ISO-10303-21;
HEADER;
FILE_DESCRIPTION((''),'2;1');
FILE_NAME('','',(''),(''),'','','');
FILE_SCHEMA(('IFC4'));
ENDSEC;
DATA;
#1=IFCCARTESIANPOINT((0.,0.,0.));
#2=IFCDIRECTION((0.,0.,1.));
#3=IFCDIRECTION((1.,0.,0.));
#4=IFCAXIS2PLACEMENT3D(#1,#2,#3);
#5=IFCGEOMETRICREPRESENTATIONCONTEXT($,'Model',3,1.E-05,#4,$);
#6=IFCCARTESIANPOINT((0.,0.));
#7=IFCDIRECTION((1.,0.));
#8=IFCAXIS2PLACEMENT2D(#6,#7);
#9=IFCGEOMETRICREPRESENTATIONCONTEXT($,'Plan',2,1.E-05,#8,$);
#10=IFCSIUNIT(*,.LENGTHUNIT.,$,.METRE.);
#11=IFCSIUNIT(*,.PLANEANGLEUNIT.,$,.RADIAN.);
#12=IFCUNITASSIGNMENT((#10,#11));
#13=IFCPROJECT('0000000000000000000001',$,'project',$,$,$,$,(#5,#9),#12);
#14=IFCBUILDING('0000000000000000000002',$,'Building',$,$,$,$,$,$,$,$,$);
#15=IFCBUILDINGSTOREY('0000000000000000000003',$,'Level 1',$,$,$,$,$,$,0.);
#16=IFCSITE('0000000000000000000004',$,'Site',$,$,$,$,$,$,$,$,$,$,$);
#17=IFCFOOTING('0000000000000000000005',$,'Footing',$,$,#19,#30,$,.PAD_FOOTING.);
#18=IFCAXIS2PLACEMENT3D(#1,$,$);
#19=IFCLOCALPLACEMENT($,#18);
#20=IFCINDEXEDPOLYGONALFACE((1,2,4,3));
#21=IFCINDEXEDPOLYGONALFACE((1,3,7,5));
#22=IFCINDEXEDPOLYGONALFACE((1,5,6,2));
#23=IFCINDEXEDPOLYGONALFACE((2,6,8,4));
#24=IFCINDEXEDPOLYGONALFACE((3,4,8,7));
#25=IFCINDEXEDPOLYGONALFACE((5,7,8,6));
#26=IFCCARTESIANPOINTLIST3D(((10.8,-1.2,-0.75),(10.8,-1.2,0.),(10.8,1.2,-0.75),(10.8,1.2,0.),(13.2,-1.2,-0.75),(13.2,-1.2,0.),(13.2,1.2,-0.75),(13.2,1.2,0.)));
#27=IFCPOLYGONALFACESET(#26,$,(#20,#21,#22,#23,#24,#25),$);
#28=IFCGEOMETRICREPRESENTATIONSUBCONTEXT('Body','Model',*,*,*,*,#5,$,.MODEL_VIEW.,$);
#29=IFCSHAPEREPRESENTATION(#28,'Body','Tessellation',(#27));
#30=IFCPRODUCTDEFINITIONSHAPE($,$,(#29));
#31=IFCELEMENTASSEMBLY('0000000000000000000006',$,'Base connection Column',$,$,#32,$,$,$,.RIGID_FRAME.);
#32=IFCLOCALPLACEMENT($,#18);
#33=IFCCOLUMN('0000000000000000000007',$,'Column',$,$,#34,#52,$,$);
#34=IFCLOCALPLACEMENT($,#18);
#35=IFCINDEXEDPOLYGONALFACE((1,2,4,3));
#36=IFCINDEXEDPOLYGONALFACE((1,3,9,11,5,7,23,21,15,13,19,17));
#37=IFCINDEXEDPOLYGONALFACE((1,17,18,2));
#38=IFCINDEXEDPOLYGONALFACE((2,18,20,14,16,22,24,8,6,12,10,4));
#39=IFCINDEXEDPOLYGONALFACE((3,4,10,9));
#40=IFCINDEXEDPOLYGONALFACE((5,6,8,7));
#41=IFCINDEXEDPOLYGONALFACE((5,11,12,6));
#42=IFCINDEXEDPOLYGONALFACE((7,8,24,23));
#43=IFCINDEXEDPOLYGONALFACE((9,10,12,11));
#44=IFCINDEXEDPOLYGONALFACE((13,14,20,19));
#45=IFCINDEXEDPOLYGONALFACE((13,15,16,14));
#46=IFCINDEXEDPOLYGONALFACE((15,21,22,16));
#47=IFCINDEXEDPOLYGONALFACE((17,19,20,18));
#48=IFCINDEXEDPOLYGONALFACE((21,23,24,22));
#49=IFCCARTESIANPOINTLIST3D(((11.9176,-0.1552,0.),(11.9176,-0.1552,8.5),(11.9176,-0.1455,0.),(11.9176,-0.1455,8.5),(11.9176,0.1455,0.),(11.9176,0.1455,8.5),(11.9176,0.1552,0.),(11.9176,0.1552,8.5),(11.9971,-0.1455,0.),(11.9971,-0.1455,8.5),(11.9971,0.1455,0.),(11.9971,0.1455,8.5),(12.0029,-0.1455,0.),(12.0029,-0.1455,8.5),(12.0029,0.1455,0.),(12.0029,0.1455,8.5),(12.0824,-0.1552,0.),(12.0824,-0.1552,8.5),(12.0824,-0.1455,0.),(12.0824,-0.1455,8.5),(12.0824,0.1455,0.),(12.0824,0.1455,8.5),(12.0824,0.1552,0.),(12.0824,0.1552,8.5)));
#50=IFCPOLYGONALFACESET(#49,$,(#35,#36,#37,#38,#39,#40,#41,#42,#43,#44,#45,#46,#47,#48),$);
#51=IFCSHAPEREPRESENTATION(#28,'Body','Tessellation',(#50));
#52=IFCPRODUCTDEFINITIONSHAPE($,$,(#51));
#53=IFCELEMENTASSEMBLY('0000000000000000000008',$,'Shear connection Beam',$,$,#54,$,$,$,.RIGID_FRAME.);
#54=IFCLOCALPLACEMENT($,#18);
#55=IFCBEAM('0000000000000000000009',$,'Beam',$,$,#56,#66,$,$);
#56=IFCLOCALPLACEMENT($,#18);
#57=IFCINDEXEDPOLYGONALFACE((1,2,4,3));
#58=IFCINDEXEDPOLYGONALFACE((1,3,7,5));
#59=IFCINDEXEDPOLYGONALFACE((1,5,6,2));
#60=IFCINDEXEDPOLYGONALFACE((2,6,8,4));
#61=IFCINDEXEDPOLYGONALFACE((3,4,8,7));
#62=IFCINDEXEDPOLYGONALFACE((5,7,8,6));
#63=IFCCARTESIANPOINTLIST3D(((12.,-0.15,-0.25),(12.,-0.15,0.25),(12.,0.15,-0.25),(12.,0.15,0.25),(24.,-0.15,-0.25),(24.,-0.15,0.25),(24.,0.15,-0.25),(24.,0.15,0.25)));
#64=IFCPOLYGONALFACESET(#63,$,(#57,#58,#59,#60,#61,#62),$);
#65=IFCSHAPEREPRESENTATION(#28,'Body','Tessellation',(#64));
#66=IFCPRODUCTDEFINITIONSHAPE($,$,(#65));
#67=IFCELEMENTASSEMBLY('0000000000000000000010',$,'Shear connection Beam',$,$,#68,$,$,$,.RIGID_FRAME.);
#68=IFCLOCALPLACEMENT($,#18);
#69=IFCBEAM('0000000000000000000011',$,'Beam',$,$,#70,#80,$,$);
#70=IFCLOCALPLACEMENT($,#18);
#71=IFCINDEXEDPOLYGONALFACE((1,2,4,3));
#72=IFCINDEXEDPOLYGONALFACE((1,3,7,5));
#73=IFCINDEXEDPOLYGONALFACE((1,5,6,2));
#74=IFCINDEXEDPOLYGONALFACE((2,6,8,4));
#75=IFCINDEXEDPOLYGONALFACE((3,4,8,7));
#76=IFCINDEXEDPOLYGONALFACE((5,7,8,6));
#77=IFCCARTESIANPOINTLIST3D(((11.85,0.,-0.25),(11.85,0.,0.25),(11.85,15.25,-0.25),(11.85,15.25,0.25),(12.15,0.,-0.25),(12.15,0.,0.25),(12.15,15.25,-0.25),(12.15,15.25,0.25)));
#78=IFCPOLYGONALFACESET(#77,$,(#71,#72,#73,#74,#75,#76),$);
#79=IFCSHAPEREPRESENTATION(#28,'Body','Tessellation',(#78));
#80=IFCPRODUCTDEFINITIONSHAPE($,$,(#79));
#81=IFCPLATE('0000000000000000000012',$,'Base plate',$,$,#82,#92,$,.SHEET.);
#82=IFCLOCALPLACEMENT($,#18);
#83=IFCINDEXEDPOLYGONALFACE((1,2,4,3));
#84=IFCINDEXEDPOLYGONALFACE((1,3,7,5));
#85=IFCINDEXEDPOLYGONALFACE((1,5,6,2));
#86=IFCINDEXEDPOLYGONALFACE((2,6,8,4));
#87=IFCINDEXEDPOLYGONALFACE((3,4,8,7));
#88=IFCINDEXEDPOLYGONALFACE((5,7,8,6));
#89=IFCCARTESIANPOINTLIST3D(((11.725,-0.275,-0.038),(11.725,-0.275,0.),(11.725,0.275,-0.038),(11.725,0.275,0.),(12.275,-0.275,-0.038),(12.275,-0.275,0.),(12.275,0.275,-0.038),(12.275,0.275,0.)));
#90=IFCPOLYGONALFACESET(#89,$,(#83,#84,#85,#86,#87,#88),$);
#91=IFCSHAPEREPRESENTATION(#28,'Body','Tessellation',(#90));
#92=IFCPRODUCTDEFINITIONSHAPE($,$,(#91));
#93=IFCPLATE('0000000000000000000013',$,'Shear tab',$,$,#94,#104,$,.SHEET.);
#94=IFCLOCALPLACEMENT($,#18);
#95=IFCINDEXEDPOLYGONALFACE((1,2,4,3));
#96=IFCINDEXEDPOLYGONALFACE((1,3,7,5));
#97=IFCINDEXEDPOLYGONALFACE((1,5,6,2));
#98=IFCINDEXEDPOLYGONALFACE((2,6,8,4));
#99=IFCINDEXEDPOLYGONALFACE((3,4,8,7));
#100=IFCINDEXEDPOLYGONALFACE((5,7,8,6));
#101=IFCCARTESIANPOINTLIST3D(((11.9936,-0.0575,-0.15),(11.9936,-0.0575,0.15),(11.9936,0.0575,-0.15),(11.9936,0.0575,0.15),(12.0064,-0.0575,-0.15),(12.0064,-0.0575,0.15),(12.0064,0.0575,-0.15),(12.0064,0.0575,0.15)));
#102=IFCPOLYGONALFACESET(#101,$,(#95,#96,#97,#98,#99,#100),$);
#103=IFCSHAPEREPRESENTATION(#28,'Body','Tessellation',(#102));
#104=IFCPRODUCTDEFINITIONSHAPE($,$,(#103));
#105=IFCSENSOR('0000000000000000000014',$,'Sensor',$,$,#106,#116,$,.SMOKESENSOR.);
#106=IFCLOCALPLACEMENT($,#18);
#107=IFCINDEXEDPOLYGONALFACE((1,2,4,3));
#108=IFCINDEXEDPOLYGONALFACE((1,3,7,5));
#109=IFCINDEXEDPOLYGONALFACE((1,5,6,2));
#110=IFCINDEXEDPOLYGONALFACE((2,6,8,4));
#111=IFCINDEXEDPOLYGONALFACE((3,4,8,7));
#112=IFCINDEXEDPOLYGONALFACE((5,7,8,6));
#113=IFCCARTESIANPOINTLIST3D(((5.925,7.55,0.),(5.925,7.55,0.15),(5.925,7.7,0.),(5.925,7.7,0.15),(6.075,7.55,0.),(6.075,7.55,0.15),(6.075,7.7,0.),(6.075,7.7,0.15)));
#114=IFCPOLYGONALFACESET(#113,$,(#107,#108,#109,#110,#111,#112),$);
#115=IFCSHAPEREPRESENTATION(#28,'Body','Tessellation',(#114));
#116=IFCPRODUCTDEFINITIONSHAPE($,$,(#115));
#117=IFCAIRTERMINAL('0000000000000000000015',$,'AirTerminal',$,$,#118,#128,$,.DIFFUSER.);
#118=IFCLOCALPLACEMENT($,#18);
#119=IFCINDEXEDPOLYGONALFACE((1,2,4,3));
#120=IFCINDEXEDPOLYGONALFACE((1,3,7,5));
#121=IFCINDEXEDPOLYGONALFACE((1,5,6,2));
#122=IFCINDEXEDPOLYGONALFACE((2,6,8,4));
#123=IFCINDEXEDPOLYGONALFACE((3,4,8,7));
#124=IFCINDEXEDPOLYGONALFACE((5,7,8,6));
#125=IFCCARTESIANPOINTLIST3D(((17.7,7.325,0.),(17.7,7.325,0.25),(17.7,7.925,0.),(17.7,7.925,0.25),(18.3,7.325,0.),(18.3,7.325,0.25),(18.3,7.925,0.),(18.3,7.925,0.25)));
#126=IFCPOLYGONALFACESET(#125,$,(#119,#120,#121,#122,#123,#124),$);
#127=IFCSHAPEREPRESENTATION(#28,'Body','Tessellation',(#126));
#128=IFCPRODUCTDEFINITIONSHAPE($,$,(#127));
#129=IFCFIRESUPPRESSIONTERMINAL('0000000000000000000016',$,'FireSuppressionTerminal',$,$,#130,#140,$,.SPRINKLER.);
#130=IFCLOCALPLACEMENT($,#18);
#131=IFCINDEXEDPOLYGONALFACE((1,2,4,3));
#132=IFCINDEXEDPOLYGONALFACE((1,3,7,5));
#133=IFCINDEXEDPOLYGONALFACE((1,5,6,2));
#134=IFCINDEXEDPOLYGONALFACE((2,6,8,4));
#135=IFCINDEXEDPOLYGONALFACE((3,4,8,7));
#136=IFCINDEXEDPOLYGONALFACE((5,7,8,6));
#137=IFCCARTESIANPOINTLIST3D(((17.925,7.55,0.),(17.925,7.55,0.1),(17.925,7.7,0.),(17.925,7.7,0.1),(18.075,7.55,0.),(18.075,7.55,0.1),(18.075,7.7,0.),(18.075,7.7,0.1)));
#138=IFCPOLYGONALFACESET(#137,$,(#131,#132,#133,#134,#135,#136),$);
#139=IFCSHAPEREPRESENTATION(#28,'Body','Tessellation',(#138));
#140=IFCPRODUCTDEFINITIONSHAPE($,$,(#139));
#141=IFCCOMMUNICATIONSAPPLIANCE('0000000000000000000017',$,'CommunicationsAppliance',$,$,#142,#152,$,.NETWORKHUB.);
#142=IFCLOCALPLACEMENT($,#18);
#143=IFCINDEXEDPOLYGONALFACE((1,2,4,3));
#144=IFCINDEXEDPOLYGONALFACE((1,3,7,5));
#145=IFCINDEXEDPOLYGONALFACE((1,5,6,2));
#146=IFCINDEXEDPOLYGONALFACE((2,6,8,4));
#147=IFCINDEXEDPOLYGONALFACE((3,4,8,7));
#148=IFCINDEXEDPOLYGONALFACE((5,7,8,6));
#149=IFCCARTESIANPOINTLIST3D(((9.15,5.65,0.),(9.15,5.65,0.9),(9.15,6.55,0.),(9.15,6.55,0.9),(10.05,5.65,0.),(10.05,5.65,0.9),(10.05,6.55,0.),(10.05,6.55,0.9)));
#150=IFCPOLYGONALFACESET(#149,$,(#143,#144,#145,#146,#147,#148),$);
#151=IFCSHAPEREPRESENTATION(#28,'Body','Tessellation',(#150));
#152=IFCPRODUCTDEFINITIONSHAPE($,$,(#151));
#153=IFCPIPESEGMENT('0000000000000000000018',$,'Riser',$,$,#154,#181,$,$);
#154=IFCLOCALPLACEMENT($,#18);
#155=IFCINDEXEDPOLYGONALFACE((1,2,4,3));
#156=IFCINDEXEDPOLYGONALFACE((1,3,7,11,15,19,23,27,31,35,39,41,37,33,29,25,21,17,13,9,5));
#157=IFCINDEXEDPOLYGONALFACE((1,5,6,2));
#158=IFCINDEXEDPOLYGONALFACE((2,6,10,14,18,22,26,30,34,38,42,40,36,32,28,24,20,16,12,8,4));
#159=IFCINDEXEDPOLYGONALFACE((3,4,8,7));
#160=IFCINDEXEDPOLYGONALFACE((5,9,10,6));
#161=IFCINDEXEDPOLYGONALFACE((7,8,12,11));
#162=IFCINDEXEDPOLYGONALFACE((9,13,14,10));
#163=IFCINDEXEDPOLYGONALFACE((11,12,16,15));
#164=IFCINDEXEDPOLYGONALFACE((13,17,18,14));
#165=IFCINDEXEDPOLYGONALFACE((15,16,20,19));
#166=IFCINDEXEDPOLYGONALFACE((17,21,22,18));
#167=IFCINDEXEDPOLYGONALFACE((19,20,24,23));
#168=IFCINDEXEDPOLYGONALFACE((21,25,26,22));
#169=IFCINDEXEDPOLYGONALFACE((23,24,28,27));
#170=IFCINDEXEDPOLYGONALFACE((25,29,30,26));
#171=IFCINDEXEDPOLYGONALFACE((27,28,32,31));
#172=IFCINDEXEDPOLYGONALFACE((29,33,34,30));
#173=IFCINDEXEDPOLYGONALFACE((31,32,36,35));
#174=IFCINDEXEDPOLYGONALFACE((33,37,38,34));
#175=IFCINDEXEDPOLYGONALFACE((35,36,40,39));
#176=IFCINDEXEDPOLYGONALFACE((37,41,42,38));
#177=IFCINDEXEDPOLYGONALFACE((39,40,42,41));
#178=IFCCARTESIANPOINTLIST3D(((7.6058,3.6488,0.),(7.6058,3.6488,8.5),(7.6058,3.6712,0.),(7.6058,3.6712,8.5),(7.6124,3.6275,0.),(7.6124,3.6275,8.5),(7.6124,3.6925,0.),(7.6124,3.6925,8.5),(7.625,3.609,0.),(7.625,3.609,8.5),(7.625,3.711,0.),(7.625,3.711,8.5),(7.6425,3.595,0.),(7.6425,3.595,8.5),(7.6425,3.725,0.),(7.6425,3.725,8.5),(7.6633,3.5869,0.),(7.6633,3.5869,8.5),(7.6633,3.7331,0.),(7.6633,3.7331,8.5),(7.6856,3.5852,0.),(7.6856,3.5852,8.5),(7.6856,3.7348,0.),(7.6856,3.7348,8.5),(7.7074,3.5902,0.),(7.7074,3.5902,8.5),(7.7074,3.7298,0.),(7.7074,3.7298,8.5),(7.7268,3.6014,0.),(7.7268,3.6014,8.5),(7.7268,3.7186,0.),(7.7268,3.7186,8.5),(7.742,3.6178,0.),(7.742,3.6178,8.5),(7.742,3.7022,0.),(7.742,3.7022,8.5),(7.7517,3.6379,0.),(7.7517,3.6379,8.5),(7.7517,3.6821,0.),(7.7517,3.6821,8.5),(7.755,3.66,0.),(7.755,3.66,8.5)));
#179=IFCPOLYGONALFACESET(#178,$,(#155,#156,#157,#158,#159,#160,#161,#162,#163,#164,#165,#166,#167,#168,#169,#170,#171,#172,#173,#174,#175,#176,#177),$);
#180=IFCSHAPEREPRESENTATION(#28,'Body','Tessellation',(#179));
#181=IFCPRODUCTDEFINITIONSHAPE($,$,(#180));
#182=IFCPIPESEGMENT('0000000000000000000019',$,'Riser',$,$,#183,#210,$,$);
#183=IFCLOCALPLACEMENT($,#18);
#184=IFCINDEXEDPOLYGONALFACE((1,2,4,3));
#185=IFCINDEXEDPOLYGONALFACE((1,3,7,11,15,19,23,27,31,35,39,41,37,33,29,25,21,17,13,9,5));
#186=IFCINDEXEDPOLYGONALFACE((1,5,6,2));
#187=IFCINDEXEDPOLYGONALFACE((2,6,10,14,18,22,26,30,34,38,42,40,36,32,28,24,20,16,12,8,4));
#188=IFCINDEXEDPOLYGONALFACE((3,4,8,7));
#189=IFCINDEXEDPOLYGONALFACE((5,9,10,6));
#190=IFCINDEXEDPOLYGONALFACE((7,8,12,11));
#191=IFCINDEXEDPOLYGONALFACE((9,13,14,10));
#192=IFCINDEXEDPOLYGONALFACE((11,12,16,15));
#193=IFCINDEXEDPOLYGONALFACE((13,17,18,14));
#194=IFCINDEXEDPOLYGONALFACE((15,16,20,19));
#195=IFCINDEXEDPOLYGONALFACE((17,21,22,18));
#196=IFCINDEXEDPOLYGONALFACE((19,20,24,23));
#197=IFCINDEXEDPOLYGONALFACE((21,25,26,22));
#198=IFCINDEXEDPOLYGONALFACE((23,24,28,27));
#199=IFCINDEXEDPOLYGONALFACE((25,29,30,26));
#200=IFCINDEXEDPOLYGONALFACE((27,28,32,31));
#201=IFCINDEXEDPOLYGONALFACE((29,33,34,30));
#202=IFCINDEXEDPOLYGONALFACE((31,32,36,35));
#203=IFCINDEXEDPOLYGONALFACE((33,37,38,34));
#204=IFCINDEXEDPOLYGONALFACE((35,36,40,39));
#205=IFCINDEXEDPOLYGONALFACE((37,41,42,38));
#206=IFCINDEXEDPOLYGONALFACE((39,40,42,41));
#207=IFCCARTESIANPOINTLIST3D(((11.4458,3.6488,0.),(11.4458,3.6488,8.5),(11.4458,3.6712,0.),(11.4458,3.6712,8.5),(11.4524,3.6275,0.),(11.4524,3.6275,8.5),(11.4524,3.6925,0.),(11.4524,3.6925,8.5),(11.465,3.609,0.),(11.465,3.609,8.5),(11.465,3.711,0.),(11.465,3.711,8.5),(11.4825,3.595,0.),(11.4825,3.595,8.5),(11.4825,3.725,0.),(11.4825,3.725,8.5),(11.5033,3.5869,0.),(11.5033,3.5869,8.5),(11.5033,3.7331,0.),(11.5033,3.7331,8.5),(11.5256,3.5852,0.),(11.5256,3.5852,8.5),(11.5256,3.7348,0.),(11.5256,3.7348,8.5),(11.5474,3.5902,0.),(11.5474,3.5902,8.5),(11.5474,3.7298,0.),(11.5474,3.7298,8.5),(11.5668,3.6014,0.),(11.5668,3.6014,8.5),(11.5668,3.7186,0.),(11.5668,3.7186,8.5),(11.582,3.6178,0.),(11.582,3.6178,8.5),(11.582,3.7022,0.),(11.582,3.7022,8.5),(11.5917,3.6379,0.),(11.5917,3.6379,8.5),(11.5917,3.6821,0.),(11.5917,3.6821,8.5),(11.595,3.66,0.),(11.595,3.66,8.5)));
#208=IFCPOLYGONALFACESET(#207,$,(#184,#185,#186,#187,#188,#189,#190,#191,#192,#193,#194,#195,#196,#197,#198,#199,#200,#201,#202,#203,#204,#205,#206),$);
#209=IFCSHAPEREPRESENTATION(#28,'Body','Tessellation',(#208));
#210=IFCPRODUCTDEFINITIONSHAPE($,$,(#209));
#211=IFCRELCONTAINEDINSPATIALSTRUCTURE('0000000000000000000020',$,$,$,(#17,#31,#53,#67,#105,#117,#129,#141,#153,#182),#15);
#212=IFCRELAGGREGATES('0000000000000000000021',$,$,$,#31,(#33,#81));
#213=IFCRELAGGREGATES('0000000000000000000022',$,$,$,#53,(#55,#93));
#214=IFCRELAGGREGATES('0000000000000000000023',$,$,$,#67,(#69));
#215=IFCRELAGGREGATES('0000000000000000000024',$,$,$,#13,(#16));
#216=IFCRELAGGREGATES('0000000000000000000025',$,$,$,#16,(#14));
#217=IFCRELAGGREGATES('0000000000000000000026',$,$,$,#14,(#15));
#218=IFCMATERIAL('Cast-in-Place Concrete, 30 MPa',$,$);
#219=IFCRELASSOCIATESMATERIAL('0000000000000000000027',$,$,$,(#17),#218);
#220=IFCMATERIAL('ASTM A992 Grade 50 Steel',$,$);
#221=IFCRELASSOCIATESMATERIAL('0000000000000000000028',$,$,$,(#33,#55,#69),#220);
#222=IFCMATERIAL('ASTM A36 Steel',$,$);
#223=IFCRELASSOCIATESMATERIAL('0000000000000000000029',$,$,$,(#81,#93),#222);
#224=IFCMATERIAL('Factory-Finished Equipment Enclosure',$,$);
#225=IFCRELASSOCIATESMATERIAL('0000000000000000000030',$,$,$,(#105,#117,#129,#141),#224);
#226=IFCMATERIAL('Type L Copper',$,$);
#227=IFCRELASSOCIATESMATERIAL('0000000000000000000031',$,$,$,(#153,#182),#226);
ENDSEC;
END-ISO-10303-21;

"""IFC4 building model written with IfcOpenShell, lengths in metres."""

from ifc_helpers import new_model, si_unit, frame, origin_with_axes, origin_2d_with_axis, place, context, subcontext, project, spatial, rectangle, circle, i_section, extrude, material, element, aggregate, save


model = new_model("IFC4")

# Units and contexts
model_context = context("Model", 3, precision=1e-05, world=origin_with_axes())
plan_context = context("Plan", 2, precision=1e-05, world=origin_2d_with_axis())
body_context = subcontext(model_context, "Body", "Model", "MODEL_VIEW")
ifc_project = project(units=[si_unit("LENGTHUNIT", "METRE"), si_unit("PLANEANGLEUNIT", "RADIAN")], contexts=[model_context, plan_context])

# Site, building, storey
site = spatial("IfcSite", under=ifc_project, Name="Site")
building = spatial("IfcBuilding", under=site, Name="Building")
storey = spatial("IfcBuildingStorey", under=building, Name="Level 1", Elevation=0.0)

# Footing
ifc_material_1 = material(Name="Cast-in-Place Concrete, 30 MPa")
footing_placement = place(None, frame((12.0, 0.0, -0.75), z_axis=(0.0, 0.0, 1.0), x_axis=(1.0, 0.0, 0.0)))
element("IfcFooting", 1, at=footing_placement, inside=storey, material=ifc_material_1, Name="Footing", PredefinedType="PAD_FOOTING", context=body_context, shape_type="SweptSolid", body=[
    extrude(rectangle(XDim=2.4, YDim=2.4, at=origin_2d_with_axis()), origin_with_axes(), (0.0, 0.0, 1.0), 0.75),
])

# Element assembly, column
assembly_1 = element("IfcElementAssembly", 2, inside=storey, Name="Base connection Column", PredefinedType="RIGID_FRAME")
ifc_material_2 = material(Name="ASTM A992 Grade 50 Steel")
column_placement = place(None, frame((12.0, 0.0, 0.0), z_axis=(0.0, 0.0, 1.0), x_axis=(1.0, 0.0, 0.0)))
column = element("IfcColumn", 3, at=column_placement, material=ifc_material_2, Name="Column", context=body_context, shape_type="SweptSolid", body=[
    extrude(i_section(OverallWidth=0.1648, OverallDepth=0.3104, WebThickness=0.0058, FlangeThickness=0.0097, at=origin_2d_with_axis()), origin_with_axes(), (0.0, 0.0, 1.0), 8.5),
])

# Element assemblies, beams
assembly_2 = element("IfcElementAssembly", 4, inside=storey, Name="Shear connection Beam", PredefinedType="RIGID_FRAME")
beam_1_placement = place(None, frame((12.0, 0.0, 0.0), z_axis=(1.0, 0.0, 0.0), x_axis=(0.0, 1.0, 0.0)))
beam_1 = element("IfcBeam", 5, at=beam_1_placement, material=ifc_material_2, Name="Beam", context=body_context, shape_type="SweptSolid", body=[
    extrude(rectangle(XDim=0.3, YDim=0.5, at=origin_2d_with_axis()), origin_with_axes(), (0.0, 0.0, 1.0), 12.0),
])
assembly_3 = element("IfcElementAssembly", 6, inside=storey, Name="Shear connection Beam", PredefinedType="RIGID_FRAME")
beam_2_placement = place(None, frame((12.0, 0.0, 0.0), z_axis=(0.0, 1.0, 0.0), x_axis=(-1.0, 0.0, 0.0)))
beam_2 = element("IfcBeam", 7, at=beam_2_placement, material=ifc_material_2, Name="Beam", context=body_context, shape_type="SweptSolid", body=[
    extrude(rectangle(XDim=0.3, YDim=0.5, at=origin_2d_with_axis()), origin_with_axes(), (0.0, 0.0, 1.0), 15.25),
])

# Plates
ifc_material_3 = material(Name="ASTM A36 Steel")
plate_1_placement = place(None, frame((12.0, 0.0, -0.038), z_axis=(0.0, 0.0, 1.0), x_axis=(1.0, 0.0, 0.0)))
plate_1 = element("IfcPlate", 8, at=plate_1_placement, material=ifc_material_3, Name="Base plate", PredefinedType="SHEET", context=body_context, shape_type="SweptSolid", body=[
    extrude(rectangle(XDim=0.55, YDim=0.55, at=origin_2d_with_axis()), origin_with_axes(), (0.0, 0.0, 1.0), 0.038),
])
plate_2_placement = place(None, frame((12.0, 0.0, -0.15), z_axis=(0.0, 0.0, 1.0), x_axis=(1.0, 0.0, 0.0)))
plate_2 = element("IfcPlate", 9, at=plate_2_placement, material=ifc_material_3, Name="Shear tab", PredefinedType="SHEET", context=body_context, shape_type="SweptSolid", body=[
    extrude(rectangle(XDim=0.0127, YDim=0.115, at=origin_2d_with_axis()), origin_with_axes(), (0.0, 0.0, 1.0), 0.3),
])

# Sensor
ifc_material_4 = material(Name="Factory-Finished Equipment Enclosure")
sensor_placement = place(None, frame((6.0, 7.625, 0.0), z_axis=(0.0, 0.0, 1.0), x_axis=(1.0, 0.0, 0.0)))
element("IfcSensor", 10, at=sensor_placement, inside=storey, material=ifc_material_4, Name="Sensor", PredefinedType="SMOKESENSOR", context=body_context, shape_type="SweptSolid", body=[
    extrude(rectangle(XDim=0.15, YDim=0.15, at=origin_2d_with_axis()), origin_with_axes(), (0.0, 0.0, 1.0), 0.15),
])

# Air terminal
air_terminal_placement = place(None, frame((18.0, 7.625, 0.0), z_axis=(0.0, 0.0, 1.0), x_axis=(1.0, 0.0, 0.0)))
element("IfcAirTerminal", 11, at=air_terminal_placement, inside=storey, material=ifc_material_4, Name="AirTerminal", PredefinedType="DIFFUSER", context=body_context, shape_type="SweptSolid", body=[
    extrude(rectangle(XDim=0.6, YDim=0.6, at=origin_2d_with_axis()), origin_with_axes(), (0.0, 0.0, 1.0), 0.25),
])

# Fire suppression terminal
fire_suppression_terminal_placement = place(None, frame((18.0, 7.625, 0.0), z_axis=(0.0, 0.0, 1.0), x_axis=(1.0, 0.0, 0.0)))
element("IfcFireSuppressionTerminal", 12, at=fire_suppression_terminal_placement, inside=storey, material=ifc_material_4, Name="FireSuppressionTerminal", PredefinedType="SPRINKLER", context=body_context, shape_type="SweptSolid", body=[
    extrude(rectangle(XDim=0.15, YDim=0.15, at=origin_2d_with_axis()), origin_with_axes(), (0.0, 0.0, 1.0), 0.1),
])

# Communications appliance
communications_appliance_placement = place(None, frame((9.6, 6.1, 0.0), z_axis=(0.0, 0.0, 1.0), x_axis=(1.0, 0.0, 0.0)))
element("IfcCommunicationsAppliance", 13, at=communications_appliance_placement, inside=storey, material=ifc_material_4, Name="CommunicationsAppliance", PredefinedType="NETWORKHUB", context=body_context, shape_type="SweptSolid", body=[
    extrude(rectangle(XDim=0.9, YDim=0.9, at=origin_2d_with_axis()), origin_with_axes(), (0.0, 0.0, 1.0), 0.9),
])

# Pipe segments
ifc_material_5 = material(Name="Type L Copper")
for number, where, z_axis, x_axis, name in (
    (14, (7.68, 3.66, 0.0), (0.0, 0.0, 1.0), (1.0, 0.0, 0.0), "Riser"),
    (15, (11.52, 3.66, 0.0), (0.0, 0.0, 1.0), (1.0, 0.0, 0.0), "Riser"),
):
    element("IfcPipeSegment", number, at=place(None, frame(where, z_axis=z_axis, x_axis=x_axis)), inside=storey, material=ifc_material_5, Name=name, context=body_context, shape_type="SweptSolid", body=[
        extrude(circle(Radius=0.075), origin_with_axes(), (0.0, 0.0, 1.0), 8.5),
    ])

aggregate(assembly_1, [column, plate_1])

aggregate(assembly_2, [beam_1, plate_2])
aggregate(assembly_3, [beam_2])

save(model, "model.ifc")
